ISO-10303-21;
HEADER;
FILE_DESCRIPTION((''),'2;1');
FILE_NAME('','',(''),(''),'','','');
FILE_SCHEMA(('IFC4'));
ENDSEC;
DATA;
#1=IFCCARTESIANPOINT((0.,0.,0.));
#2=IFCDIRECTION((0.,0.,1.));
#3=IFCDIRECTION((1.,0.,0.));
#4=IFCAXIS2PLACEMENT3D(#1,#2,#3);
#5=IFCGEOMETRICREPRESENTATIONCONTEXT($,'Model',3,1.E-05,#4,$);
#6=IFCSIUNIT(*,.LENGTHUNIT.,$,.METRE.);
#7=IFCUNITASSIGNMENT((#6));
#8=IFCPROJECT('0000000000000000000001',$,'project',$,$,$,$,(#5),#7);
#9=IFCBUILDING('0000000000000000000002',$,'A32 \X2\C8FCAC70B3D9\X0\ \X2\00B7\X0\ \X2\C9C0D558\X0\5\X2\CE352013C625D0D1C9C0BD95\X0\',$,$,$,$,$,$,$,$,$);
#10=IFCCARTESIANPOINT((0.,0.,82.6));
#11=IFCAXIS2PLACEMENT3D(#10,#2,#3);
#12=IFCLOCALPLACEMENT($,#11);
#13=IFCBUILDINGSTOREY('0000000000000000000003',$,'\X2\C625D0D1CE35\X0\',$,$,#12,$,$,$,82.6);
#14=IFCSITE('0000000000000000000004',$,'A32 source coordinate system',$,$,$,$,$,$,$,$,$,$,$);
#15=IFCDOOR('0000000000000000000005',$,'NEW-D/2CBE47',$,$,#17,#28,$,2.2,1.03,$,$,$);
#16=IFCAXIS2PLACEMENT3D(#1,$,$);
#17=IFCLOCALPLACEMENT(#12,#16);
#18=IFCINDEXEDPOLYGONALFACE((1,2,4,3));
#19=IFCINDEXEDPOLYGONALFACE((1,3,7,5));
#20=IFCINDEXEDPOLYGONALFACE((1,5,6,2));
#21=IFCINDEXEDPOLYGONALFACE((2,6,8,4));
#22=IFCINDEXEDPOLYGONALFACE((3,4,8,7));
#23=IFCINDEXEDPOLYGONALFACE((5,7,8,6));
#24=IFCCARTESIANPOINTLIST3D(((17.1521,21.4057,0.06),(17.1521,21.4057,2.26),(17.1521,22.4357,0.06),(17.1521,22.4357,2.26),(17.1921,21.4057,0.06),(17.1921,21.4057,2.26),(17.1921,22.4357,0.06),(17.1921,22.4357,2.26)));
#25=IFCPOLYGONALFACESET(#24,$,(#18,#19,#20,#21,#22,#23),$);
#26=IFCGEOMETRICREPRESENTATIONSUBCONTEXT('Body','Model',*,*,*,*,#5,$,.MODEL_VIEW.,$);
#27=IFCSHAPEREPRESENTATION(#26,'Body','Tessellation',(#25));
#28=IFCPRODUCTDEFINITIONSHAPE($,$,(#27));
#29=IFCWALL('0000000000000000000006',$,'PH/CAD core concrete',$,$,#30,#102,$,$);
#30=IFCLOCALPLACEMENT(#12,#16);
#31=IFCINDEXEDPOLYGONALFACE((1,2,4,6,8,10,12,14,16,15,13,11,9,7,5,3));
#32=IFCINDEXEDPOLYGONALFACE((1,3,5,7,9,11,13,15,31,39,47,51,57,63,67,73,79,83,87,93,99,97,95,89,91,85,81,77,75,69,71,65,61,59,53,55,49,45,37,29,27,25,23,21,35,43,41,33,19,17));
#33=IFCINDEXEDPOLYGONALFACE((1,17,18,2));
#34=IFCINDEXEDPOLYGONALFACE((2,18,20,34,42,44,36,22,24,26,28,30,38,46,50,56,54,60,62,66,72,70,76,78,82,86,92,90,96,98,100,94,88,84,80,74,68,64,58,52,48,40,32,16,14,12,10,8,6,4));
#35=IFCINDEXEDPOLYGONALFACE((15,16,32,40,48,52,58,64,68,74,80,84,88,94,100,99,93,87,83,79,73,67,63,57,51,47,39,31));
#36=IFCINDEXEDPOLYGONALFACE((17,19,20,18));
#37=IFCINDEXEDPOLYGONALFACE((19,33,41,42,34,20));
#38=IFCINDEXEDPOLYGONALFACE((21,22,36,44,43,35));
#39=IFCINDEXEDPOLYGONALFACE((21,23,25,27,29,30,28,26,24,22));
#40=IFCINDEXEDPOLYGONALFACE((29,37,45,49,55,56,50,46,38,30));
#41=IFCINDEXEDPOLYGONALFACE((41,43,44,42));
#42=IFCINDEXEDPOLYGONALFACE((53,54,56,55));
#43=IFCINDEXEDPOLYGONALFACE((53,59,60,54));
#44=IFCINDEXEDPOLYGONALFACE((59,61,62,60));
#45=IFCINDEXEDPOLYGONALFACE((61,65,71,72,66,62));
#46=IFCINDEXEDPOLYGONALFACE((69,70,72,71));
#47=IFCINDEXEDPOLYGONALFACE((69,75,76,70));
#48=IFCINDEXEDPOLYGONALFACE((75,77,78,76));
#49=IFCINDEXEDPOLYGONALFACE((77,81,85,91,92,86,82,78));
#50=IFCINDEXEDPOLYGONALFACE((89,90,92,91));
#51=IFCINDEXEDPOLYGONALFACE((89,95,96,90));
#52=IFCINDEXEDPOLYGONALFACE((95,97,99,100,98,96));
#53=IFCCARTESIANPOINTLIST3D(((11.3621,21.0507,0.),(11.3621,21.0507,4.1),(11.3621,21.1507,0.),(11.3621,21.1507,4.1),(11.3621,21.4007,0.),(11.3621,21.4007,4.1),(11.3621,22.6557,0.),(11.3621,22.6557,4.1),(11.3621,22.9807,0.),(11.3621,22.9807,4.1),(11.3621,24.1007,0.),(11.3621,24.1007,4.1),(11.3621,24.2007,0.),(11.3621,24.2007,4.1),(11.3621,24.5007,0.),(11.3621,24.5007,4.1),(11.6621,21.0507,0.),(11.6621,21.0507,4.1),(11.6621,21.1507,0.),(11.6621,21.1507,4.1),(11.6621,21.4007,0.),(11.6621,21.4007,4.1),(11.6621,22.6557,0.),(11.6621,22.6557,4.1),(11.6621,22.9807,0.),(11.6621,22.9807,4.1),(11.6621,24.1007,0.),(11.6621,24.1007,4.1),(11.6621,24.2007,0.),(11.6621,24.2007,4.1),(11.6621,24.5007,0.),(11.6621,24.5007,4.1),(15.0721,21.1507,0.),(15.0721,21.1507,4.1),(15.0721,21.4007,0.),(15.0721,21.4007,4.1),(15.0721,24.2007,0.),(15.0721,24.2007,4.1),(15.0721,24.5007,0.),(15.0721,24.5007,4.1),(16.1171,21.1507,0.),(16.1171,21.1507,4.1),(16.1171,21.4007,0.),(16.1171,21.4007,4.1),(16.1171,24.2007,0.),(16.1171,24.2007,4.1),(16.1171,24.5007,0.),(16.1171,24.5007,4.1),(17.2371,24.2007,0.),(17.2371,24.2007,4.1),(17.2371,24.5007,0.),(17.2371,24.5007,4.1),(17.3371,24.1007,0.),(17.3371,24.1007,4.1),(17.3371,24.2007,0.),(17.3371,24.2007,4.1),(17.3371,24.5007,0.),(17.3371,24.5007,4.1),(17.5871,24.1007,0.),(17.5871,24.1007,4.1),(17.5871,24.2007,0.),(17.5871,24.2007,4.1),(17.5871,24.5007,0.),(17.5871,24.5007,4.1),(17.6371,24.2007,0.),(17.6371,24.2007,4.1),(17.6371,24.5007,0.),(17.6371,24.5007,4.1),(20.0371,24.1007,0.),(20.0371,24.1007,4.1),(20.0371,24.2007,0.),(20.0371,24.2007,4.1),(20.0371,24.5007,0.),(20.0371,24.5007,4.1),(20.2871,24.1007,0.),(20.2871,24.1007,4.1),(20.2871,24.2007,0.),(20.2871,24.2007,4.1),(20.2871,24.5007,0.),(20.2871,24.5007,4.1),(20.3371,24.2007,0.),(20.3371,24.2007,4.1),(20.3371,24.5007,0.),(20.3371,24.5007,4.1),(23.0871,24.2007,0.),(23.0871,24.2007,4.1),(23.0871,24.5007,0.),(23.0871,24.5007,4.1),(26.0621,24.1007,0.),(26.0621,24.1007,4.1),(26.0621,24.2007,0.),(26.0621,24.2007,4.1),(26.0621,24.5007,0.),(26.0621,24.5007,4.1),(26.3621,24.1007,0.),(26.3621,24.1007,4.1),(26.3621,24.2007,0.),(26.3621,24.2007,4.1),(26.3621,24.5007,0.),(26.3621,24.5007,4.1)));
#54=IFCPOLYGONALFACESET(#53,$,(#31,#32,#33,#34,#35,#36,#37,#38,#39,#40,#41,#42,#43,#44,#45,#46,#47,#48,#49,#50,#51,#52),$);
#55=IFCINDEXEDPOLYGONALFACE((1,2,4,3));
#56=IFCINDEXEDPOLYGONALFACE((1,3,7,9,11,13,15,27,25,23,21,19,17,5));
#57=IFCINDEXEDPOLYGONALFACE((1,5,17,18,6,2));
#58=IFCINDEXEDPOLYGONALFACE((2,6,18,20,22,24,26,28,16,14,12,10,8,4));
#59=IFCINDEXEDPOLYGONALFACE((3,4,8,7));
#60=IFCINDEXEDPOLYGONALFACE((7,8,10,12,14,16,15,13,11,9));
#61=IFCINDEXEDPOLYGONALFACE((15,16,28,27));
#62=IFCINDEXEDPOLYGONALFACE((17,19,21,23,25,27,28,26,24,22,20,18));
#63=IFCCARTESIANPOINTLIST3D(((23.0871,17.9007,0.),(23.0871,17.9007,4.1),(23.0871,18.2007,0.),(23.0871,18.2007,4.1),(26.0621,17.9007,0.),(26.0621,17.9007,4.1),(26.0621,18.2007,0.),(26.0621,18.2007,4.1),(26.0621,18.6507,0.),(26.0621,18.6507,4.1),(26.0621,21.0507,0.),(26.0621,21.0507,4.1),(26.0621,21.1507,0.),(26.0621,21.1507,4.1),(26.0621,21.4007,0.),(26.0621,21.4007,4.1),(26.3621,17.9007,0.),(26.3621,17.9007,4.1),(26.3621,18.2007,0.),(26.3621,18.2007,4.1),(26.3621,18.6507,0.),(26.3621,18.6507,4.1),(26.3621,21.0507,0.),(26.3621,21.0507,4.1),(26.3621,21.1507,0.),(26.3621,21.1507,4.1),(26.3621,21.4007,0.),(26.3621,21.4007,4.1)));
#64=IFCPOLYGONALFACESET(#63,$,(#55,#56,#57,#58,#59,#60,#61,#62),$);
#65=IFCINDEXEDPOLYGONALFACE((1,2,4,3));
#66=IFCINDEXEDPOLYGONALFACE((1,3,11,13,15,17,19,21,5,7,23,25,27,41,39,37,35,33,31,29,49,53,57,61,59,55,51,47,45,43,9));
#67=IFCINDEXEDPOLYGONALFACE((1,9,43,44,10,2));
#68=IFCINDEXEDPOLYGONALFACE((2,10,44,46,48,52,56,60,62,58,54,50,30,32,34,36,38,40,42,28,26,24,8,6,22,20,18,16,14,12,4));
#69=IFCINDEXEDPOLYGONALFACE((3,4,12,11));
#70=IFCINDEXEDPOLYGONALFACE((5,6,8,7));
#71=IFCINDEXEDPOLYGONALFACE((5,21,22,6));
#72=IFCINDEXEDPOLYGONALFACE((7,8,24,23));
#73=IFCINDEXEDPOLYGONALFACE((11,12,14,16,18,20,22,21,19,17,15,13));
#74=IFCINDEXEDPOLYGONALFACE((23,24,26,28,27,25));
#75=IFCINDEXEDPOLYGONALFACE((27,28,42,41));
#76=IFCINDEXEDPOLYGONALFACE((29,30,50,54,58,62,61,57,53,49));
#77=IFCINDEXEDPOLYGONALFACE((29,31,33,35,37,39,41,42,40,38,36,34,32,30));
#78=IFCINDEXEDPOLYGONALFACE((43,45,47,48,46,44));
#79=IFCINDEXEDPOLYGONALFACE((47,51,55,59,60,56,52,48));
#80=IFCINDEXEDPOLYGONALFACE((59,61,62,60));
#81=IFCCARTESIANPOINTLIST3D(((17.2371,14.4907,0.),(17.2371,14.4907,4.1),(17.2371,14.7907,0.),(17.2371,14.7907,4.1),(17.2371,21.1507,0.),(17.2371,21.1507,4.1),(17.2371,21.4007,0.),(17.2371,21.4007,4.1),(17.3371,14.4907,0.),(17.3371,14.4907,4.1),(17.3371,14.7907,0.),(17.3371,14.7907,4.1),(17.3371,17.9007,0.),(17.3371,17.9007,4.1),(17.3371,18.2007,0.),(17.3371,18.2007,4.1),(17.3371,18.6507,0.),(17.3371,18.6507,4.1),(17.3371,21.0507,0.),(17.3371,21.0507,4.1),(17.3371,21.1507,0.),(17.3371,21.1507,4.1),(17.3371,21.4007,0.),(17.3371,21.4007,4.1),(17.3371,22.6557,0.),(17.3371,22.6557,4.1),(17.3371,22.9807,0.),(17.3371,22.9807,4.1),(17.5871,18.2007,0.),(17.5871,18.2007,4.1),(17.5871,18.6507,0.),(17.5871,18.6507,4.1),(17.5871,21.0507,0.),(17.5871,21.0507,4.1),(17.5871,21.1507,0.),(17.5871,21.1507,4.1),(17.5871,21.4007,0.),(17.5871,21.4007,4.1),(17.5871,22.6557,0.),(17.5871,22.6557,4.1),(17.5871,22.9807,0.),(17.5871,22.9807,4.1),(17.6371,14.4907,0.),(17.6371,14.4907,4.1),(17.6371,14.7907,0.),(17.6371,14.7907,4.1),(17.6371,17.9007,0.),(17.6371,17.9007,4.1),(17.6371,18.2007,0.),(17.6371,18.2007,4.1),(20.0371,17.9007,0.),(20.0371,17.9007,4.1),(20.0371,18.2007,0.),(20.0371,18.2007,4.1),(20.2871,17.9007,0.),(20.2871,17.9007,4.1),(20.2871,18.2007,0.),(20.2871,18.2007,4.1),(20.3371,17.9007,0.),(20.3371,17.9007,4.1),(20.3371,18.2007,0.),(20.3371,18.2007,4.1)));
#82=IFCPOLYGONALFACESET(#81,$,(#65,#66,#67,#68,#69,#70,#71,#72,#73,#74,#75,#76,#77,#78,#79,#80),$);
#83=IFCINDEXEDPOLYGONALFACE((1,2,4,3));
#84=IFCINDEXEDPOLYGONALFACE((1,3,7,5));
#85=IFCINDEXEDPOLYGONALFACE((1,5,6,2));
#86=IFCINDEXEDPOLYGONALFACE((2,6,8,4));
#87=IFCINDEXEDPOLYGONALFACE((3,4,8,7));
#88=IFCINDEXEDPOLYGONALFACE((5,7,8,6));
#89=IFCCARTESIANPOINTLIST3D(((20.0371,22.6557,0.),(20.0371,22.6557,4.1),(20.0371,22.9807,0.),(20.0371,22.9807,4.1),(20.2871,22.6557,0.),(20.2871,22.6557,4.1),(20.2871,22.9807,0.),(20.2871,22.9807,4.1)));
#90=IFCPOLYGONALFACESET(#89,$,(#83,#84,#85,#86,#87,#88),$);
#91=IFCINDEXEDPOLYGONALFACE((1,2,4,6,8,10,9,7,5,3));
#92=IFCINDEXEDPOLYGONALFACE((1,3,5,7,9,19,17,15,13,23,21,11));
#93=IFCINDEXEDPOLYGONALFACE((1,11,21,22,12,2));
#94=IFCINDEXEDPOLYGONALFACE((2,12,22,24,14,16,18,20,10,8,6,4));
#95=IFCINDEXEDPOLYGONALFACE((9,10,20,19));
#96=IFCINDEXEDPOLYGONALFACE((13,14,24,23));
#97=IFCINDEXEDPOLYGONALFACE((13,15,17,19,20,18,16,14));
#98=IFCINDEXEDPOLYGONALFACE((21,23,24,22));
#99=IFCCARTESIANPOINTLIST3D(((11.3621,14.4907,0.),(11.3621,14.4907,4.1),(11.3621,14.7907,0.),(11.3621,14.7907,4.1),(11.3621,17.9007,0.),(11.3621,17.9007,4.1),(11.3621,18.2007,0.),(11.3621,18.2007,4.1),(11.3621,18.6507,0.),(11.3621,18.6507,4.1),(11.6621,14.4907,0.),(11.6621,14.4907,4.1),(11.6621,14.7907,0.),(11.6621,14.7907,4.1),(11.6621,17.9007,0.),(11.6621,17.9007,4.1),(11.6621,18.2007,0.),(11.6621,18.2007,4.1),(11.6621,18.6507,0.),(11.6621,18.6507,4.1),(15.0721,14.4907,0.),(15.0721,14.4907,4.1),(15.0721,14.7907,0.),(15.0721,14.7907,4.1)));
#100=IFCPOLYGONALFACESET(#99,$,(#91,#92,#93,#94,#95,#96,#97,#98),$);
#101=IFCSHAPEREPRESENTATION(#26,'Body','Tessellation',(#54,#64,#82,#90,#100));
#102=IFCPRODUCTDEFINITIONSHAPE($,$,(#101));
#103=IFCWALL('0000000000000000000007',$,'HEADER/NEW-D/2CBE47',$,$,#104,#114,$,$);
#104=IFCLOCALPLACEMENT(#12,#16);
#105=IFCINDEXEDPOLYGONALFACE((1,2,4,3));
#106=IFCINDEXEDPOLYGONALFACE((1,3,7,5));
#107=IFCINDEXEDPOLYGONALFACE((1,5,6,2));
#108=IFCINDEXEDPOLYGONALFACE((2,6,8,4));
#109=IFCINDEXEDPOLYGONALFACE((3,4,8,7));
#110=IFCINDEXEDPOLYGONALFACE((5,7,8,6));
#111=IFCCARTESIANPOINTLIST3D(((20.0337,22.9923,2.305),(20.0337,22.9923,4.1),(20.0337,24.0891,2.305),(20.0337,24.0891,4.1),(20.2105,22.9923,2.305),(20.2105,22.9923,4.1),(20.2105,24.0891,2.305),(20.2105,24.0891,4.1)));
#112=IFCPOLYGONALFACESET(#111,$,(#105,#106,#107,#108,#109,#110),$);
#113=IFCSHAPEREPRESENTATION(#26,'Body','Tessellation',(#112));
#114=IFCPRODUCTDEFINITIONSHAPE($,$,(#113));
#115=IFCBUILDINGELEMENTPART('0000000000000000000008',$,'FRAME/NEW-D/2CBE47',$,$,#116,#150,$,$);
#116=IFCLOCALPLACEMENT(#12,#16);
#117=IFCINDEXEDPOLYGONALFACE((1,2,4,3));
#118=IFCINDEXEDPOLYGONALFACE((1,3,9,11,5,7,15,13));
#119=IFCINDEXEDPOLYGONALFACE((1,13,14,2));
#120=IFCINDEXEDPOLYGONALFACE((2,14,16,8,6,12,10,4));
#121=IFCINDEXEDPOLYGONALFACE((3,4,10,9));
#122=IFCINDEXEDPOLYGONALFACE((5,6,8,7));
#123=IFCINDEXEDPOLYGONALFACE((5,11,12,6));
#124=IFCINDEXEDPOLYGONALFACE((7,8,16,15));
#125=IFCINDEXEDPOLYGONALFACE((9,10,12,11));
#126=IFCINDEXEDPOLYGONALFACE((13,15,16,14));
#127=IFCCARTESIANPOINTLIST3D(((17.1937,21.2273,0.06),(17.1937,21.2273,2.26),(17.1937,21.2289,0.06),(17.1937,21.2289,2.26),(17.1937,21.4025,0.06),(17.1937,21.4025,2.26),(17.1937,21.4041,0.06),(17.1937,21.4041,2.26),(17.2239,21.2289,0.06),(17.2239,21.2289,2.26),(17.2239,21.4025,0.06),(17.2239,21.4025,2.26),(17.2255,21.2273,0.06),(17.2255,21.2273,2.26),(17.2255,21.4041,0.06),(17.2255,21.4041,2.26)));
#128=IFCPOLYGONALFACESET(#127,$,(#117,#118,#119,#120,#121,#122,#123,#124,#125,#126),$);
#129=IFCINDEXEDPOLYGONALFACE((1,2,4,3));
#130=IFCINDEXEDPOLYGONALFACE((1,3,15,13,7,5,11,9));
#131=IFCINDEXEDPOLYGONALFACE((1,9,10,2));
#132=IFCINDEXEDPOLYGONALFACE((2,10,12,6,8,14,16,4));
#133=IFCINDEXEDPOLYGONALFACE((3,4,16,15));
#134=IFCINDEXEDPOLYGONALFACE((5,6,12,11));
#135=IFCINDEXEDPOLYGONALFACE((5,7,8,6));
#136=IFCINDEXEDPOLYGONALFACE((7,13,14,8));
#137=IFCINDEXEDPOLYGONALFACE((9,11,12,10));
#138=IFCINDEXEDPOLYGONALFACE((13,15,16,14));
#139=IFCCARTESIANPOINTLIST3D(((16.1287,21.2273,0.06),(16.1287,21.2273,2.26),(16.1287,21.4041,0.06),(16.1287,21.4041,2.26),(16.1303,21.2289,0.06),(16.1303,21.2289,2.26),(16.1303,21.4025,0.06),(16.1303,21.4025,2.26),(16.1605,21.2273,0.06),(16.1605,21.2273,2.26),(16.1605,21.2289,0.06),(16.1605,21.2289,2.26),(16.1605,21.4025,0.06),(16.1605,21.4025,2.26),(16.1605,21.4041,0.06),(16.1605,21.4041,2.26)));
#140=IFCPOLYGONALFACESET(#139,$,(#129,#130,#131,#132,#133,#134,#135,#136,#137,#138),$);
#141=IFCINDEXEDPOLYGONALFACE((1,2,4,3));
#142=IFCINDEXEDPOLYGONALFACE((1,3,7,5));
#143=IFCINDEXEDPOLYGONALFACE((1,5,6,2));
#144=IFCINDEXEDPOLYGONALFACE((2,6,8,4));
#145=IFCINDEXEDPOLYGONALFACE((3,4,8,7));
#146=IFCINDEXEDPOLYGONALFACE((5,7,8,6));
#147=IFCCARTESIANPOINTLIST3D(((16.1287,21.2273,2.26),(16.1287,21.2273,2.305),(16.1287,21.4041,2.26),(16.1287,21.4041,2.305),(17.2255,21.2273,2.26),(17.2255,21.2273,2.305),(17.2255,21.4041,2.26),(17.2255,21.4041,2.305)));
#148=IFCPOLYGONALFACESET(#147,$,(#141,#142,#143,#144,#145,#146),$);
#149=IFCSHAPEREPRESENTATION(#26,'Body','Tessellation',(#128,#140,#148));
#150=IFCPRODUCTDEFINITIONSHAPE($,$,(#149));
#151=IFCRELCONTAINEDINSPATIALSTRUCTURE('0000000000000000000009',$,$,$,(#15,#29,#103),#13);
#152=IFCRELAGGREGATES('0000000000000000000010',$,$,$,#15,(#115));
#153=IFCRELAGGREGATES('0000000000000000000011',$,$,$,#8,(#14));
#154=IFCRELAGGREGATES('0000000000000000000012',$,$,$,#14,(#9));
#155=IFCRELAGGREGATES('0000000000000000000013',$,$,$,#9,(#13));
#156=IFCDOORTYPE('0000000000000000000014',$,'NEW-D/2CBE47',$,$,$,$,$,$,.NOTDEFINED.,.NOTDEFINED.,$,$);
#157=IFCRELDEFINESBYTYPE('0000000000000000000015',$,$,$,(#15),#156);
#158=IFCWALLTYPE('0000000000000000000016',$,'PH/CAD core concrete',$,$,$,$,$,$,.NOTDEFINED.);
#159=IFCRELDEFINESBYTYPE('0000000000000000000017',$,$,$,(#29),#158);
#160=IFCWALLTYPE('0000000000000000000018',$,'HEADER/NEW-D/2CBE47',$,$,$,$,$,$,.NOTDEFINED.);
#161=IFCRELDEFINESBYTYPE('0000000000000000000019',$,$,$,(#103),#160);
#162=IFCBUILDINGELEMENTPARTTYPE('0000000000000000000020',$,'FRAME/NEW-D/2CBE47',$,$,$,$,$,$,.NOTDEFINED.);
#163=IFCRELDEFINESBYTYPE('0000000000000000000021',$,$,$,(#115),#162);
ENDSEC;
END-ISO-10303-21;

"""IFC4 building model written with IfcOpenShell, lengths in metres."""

from ifc_helpers import new_model, si_unit, frame, origin, origin_with_axes, place, context, subcontext, project, spatial, polyline, outline, extrude, source, transform, mapped, type_object, type_shapes, element, aggregate, save


model = new_model("IFC4")

# Units and contexts
model_context = context("Model", 3, precision=1e-05, world=origin_with_axes())
body_context = subcontext(model_context, "Body", "Model", "MODEL_VIEW")
ifc_project = project(units=[si_unit("LENGTHUNIT", "METRE")], contexts=[model_context])

# Site, building, storey
storey_placement = place(None, frame((0.0, 0.0, 82.6), z_axis=(0.0, 0.0, 1.0), x_axis=(1.0, 0.0, 0.0)))
site = spatial("IfcSite", under=ifc_project, Name="A32 source coordinate system")
building = spatial("IfcBuilding", under=site, Name="A32 주거동 · 지하5층–옥탑지붕")
storey = spatial("IfcBuildingStorey", under=building, at=storey_placement, Name="옥탑층", Elevation=82.6)

# Door
door_type_1 = type_object("IfcDoorType", Name="NEW-D/2CBE47", OperationType="NOTDEFINED", PredefinedType="NOTDEFINED")
shared_shape_1 = source(origin(), body_context, "Body", "SweptSolid", [
    extrude(outline(polyline([(17.1921, 21.4057), (17.1521, 21.4057), (17.1521, 22.4357), (17.1921, 22.4357), (17.1921, 21.4057)])), frame((0.0, 0.0, 0.06)), (0.0, 0.0, 1.0), 2.2),
])
type_shapes(door_type_1, [shared_shape_1])
door_1_placement = place(storey_placement, origin_with_axes())
door_1 = element("IfcDoor", 1, at=door_1_placement, inside=storey, type_object=door_type_1, Name="NEW-D/2CBE47", OverallHeight=2.2, OverallWidth=1.03, context=body_context, shape_type="MappedRepresentation", body=[
    mapped(shared_shape_1, transform((0.0, 0.0, 0.0), scale=1.0)),
])

# Walls
wall_type_1 = type_object("IfcWallType", Name="PH/CAD core concrete", PredefinedType="NOTDEFINED")
shared_shape_2 = source(origin(), body_context, "Body", "SweptSolid", [
    extrude(outline(polyline([(11.3621, 21.4007), (11.3621, 22.6557), (11.3621, 22.9807), (11.3621, 24.1007), (11.3621, 24.2007), (11.3621, 24.5007), (11.6621, 24.5007), (15.0721, 24.5007), (16.1171, 24.5007), (17.2371, 24.5007), (17.3371, 24.5007), (17.5871, 24.5007), (17.6371, 24.5007), (20.0371, 24.5007), (20.2871, 24.5007), (20.3371, 24.5007), (23.0871, 24.5007), (26.0621, 24.5007), (26.3621, 24.5007), (26.3621, 24.2007), (26.3621, 24.1007), (26.0621, 24.1007), (26.0621, 24.2007), (23.0871, 24.2007), (20.3371, 24.2007), (20.2871, 24.2007), (20.2871, 24.1007), (20.0371, 24.1007), (20.0371, 24.2007), (17.6371, 24.2007), (17.5871, 24.2007), (17.5871, 24.1007), (17.3371, 24.1007), (17.3371, 24.2007), (17.2371, 24.2007), (16.1171, 24.2007), (15.0721, 24.2007), (11.6621, 24.2007), (11.6621, 24.1007), (11.6621, 22.9807), (11.6621, 22.6557), (11.6621, 21.4007), (15.0721, 21.4007), (16.1171, 21.4007), (16.1171, 21.1507), (15.0721, 21.1507), (11.6621, 21.1507), (11.6621, 21.0507), (11.3621, 21.0507), (11.3621, 21.1507), (11.3621, 21.4007)])), origin(), (0.0, 0.0, 1.0), 4.1),
    extrude(outline(polyline([(26.0621, 18.2007), (26.0621, 18.6507), (26.0621, 21.0507), (26.0621, 21.1507), (26.0621, 21.4007), (26.3621, 21.4007), (26.3621, 21.1507), (26.3621, 21.0507), (26.3621, 18.6507), (26.3621, 18.2007), (26.3621, 17.9007), (26.0621, 17.9007), (23.0871, 17.9007), (23.0871, 18.2007), (26.0621, 18.2007)])), origin(), (0.0, 0.0, 1.0), 4.1),
    extrude(outline(polyline([(17.3371, 21.4007), (17.3371, 22.6557), (17.3371, 22.9807), (17.5871, 22.9807), (17.5871, 22.6557), (17.5871, 21.4007), (17.5871, 21.1507), (17.5871, 21.0507), (17.5871, 18.6507), (17.5871, 18.2007), (17.6371, 18.2007), (20.0371, 18.2007), (20.2871, 18.2007), (20.3371, 18.2007), (20.3371, 17.9007), (20.2871, 17.9007), (20.0371, 17.9007), (17.6371, 17.9007), (17.6371, 14.7907), (17.6371, 14.4907), (17.3371, 14.4907), (17.2371, 14.4907), (17.2371, 14.7907), (17.3371, 14.7907), (17.3371, 17.9007), (17.3371, 18.2007), (17.3371, 18.6507), (17.3371, 21.0507), (17.3371, 21.1507), (17.2371, 21.1507), (17.2371, 21.4007), (17.3371, 21.4007)])), origin(), (0.0, 0.0, 1.0), 4.1),
    extrude(outline(polyline([(20.2871, 22.9807), (20.2871, 22.6557), (20.0371, 22.6557), (20.0371, 22.9807), (20.2871, 22.9807)])), origin(), (0.0, 0.0, 1.0), 4.1),
    extrude(outline(polyline([(11.3621, 18.2007), (11.3621, 18.6507), (11.6621, 18.6507), (11.6621, 18.2007), (11.6621, 17.9007), (11.6621, 14.7907), (15.0721, 14.7907), (15.0721, 14.4907), (11.6621, 14.4907), (11.3621, 14.4907), (11.3621, 14.7907), (11.3621, 17.9007), (11.3621, 18.2007)])), origin(), (0.0, 0.0, 1.0), 4.1),
])
type_shapes(wall_type_1, [shared_shape_2])
wall_1_placement = place(storey_placement, origin_with_axes())
element("IfcWall", 2, at=wall_1_placement, inside=storey, type_object=wall_type_1, Name="PH/CAD core concrete", context=body_context, shape_type="MappedRepresentation", body=[
    mapped(shared_shape_2, transform((0.0, 0.0, 0.0), scale=1.0)),
])
wall_type_2 = type_object("IfcWallType", Name="HEADER/NEW-D/2CBE47", PredefinedType="NOTDEFINED")
shared_shape_3 = source(origin(), body_context, "Body", "SweptSolid", [
    extrude(outline(polyline([(20.0337, 22.9923), (20.0337, 24.0891), (20.2105, 24.0891), (20.2105, 22.9923), (20.0337, 22.9923)])), frame((0.0, 0.0, 2.305)), (0.0, 0.0, 1.0), 1.795),
])
type_shapes(wall_type_2, [shared_shape_3])
wall_2_placement = place(storey_placement, origin_with_axes())
element("IfcWall", 3, at=wall_2_placement, inside=storey, type_object=wall_type_2, Name="HEADER/NEW-D/2CBE47", context=body_context, shape_type="MappedRepresentation", body=[
    mapped(shared_shape_3, transform((0.0, 0.0, 0.0), scale=1.0)),
])

# Building element part
building_element_part_type_1 = type_object("IfcBuildingElementPartType", Name="FRAME/NEW-D/2CBE47", PredefinedType="NOTDEFINED")
shared_shape_4 = source(origin(), body_context, "Body", "SweptSolid", [
    extrude(outline(polyline([(17.2255, 21.2273), (17.1937, 21.2273), (17.1937, 21.2289), (17.2239, 21.2289), (17.2239, 21.4025), (17.1937, 21.4025), (17.1937, 21.4041), (17.2255, 21.4041), (17.2255, 21.2273)])), frame((0.0, 0.0, 0.06)), (0.0, 0.0, 1.0), 2.2),
    extrude(outline(polyline([(16.1303, 21.4025), (16.1303, 21.2289), (16.1605, 21.2289), (16.1605, 21.2273), (16.1287, 21.2273), (16.1287, 21.4041), (16.1605, 21.4041), (16.1605, 21.4025), (16.1303, 21.4025)])), frame((0.0, 0.0, 0.06)), (0.0, 0.0, 1.0), 2.2),
    extrude(outline(polyline([(17.2255, 21.2273), (17.2255, 21.4041), (16.1287, 21.4041), (16.1287, 21.2273), (17.2255, 21.2273)])), frame((0.0, 0.0, 2.26)), (0.0, 0.0, 1.0), 0.045),
])
type_shapes(building_element_part_type_1, [shared_shape_4])
building_element_part_1_placement = place(door_1_placement, origin_with_axes())
building_element_part_1 = element("IfcBuildingElementPart", 4, at=building_element_part_1_placement, type_object=building_element_part_type_1, Name="FRAME/NEW-D/2CBE47", context=body_context, shape_type="MappedRepresentation", body=[
    mapped(shared_shape_4, transform((0.0, 0.0, 0.0), scale=1.0)),
])
aggregate(door_1, [building_element_part_1])

save(model, "model.ifc")
